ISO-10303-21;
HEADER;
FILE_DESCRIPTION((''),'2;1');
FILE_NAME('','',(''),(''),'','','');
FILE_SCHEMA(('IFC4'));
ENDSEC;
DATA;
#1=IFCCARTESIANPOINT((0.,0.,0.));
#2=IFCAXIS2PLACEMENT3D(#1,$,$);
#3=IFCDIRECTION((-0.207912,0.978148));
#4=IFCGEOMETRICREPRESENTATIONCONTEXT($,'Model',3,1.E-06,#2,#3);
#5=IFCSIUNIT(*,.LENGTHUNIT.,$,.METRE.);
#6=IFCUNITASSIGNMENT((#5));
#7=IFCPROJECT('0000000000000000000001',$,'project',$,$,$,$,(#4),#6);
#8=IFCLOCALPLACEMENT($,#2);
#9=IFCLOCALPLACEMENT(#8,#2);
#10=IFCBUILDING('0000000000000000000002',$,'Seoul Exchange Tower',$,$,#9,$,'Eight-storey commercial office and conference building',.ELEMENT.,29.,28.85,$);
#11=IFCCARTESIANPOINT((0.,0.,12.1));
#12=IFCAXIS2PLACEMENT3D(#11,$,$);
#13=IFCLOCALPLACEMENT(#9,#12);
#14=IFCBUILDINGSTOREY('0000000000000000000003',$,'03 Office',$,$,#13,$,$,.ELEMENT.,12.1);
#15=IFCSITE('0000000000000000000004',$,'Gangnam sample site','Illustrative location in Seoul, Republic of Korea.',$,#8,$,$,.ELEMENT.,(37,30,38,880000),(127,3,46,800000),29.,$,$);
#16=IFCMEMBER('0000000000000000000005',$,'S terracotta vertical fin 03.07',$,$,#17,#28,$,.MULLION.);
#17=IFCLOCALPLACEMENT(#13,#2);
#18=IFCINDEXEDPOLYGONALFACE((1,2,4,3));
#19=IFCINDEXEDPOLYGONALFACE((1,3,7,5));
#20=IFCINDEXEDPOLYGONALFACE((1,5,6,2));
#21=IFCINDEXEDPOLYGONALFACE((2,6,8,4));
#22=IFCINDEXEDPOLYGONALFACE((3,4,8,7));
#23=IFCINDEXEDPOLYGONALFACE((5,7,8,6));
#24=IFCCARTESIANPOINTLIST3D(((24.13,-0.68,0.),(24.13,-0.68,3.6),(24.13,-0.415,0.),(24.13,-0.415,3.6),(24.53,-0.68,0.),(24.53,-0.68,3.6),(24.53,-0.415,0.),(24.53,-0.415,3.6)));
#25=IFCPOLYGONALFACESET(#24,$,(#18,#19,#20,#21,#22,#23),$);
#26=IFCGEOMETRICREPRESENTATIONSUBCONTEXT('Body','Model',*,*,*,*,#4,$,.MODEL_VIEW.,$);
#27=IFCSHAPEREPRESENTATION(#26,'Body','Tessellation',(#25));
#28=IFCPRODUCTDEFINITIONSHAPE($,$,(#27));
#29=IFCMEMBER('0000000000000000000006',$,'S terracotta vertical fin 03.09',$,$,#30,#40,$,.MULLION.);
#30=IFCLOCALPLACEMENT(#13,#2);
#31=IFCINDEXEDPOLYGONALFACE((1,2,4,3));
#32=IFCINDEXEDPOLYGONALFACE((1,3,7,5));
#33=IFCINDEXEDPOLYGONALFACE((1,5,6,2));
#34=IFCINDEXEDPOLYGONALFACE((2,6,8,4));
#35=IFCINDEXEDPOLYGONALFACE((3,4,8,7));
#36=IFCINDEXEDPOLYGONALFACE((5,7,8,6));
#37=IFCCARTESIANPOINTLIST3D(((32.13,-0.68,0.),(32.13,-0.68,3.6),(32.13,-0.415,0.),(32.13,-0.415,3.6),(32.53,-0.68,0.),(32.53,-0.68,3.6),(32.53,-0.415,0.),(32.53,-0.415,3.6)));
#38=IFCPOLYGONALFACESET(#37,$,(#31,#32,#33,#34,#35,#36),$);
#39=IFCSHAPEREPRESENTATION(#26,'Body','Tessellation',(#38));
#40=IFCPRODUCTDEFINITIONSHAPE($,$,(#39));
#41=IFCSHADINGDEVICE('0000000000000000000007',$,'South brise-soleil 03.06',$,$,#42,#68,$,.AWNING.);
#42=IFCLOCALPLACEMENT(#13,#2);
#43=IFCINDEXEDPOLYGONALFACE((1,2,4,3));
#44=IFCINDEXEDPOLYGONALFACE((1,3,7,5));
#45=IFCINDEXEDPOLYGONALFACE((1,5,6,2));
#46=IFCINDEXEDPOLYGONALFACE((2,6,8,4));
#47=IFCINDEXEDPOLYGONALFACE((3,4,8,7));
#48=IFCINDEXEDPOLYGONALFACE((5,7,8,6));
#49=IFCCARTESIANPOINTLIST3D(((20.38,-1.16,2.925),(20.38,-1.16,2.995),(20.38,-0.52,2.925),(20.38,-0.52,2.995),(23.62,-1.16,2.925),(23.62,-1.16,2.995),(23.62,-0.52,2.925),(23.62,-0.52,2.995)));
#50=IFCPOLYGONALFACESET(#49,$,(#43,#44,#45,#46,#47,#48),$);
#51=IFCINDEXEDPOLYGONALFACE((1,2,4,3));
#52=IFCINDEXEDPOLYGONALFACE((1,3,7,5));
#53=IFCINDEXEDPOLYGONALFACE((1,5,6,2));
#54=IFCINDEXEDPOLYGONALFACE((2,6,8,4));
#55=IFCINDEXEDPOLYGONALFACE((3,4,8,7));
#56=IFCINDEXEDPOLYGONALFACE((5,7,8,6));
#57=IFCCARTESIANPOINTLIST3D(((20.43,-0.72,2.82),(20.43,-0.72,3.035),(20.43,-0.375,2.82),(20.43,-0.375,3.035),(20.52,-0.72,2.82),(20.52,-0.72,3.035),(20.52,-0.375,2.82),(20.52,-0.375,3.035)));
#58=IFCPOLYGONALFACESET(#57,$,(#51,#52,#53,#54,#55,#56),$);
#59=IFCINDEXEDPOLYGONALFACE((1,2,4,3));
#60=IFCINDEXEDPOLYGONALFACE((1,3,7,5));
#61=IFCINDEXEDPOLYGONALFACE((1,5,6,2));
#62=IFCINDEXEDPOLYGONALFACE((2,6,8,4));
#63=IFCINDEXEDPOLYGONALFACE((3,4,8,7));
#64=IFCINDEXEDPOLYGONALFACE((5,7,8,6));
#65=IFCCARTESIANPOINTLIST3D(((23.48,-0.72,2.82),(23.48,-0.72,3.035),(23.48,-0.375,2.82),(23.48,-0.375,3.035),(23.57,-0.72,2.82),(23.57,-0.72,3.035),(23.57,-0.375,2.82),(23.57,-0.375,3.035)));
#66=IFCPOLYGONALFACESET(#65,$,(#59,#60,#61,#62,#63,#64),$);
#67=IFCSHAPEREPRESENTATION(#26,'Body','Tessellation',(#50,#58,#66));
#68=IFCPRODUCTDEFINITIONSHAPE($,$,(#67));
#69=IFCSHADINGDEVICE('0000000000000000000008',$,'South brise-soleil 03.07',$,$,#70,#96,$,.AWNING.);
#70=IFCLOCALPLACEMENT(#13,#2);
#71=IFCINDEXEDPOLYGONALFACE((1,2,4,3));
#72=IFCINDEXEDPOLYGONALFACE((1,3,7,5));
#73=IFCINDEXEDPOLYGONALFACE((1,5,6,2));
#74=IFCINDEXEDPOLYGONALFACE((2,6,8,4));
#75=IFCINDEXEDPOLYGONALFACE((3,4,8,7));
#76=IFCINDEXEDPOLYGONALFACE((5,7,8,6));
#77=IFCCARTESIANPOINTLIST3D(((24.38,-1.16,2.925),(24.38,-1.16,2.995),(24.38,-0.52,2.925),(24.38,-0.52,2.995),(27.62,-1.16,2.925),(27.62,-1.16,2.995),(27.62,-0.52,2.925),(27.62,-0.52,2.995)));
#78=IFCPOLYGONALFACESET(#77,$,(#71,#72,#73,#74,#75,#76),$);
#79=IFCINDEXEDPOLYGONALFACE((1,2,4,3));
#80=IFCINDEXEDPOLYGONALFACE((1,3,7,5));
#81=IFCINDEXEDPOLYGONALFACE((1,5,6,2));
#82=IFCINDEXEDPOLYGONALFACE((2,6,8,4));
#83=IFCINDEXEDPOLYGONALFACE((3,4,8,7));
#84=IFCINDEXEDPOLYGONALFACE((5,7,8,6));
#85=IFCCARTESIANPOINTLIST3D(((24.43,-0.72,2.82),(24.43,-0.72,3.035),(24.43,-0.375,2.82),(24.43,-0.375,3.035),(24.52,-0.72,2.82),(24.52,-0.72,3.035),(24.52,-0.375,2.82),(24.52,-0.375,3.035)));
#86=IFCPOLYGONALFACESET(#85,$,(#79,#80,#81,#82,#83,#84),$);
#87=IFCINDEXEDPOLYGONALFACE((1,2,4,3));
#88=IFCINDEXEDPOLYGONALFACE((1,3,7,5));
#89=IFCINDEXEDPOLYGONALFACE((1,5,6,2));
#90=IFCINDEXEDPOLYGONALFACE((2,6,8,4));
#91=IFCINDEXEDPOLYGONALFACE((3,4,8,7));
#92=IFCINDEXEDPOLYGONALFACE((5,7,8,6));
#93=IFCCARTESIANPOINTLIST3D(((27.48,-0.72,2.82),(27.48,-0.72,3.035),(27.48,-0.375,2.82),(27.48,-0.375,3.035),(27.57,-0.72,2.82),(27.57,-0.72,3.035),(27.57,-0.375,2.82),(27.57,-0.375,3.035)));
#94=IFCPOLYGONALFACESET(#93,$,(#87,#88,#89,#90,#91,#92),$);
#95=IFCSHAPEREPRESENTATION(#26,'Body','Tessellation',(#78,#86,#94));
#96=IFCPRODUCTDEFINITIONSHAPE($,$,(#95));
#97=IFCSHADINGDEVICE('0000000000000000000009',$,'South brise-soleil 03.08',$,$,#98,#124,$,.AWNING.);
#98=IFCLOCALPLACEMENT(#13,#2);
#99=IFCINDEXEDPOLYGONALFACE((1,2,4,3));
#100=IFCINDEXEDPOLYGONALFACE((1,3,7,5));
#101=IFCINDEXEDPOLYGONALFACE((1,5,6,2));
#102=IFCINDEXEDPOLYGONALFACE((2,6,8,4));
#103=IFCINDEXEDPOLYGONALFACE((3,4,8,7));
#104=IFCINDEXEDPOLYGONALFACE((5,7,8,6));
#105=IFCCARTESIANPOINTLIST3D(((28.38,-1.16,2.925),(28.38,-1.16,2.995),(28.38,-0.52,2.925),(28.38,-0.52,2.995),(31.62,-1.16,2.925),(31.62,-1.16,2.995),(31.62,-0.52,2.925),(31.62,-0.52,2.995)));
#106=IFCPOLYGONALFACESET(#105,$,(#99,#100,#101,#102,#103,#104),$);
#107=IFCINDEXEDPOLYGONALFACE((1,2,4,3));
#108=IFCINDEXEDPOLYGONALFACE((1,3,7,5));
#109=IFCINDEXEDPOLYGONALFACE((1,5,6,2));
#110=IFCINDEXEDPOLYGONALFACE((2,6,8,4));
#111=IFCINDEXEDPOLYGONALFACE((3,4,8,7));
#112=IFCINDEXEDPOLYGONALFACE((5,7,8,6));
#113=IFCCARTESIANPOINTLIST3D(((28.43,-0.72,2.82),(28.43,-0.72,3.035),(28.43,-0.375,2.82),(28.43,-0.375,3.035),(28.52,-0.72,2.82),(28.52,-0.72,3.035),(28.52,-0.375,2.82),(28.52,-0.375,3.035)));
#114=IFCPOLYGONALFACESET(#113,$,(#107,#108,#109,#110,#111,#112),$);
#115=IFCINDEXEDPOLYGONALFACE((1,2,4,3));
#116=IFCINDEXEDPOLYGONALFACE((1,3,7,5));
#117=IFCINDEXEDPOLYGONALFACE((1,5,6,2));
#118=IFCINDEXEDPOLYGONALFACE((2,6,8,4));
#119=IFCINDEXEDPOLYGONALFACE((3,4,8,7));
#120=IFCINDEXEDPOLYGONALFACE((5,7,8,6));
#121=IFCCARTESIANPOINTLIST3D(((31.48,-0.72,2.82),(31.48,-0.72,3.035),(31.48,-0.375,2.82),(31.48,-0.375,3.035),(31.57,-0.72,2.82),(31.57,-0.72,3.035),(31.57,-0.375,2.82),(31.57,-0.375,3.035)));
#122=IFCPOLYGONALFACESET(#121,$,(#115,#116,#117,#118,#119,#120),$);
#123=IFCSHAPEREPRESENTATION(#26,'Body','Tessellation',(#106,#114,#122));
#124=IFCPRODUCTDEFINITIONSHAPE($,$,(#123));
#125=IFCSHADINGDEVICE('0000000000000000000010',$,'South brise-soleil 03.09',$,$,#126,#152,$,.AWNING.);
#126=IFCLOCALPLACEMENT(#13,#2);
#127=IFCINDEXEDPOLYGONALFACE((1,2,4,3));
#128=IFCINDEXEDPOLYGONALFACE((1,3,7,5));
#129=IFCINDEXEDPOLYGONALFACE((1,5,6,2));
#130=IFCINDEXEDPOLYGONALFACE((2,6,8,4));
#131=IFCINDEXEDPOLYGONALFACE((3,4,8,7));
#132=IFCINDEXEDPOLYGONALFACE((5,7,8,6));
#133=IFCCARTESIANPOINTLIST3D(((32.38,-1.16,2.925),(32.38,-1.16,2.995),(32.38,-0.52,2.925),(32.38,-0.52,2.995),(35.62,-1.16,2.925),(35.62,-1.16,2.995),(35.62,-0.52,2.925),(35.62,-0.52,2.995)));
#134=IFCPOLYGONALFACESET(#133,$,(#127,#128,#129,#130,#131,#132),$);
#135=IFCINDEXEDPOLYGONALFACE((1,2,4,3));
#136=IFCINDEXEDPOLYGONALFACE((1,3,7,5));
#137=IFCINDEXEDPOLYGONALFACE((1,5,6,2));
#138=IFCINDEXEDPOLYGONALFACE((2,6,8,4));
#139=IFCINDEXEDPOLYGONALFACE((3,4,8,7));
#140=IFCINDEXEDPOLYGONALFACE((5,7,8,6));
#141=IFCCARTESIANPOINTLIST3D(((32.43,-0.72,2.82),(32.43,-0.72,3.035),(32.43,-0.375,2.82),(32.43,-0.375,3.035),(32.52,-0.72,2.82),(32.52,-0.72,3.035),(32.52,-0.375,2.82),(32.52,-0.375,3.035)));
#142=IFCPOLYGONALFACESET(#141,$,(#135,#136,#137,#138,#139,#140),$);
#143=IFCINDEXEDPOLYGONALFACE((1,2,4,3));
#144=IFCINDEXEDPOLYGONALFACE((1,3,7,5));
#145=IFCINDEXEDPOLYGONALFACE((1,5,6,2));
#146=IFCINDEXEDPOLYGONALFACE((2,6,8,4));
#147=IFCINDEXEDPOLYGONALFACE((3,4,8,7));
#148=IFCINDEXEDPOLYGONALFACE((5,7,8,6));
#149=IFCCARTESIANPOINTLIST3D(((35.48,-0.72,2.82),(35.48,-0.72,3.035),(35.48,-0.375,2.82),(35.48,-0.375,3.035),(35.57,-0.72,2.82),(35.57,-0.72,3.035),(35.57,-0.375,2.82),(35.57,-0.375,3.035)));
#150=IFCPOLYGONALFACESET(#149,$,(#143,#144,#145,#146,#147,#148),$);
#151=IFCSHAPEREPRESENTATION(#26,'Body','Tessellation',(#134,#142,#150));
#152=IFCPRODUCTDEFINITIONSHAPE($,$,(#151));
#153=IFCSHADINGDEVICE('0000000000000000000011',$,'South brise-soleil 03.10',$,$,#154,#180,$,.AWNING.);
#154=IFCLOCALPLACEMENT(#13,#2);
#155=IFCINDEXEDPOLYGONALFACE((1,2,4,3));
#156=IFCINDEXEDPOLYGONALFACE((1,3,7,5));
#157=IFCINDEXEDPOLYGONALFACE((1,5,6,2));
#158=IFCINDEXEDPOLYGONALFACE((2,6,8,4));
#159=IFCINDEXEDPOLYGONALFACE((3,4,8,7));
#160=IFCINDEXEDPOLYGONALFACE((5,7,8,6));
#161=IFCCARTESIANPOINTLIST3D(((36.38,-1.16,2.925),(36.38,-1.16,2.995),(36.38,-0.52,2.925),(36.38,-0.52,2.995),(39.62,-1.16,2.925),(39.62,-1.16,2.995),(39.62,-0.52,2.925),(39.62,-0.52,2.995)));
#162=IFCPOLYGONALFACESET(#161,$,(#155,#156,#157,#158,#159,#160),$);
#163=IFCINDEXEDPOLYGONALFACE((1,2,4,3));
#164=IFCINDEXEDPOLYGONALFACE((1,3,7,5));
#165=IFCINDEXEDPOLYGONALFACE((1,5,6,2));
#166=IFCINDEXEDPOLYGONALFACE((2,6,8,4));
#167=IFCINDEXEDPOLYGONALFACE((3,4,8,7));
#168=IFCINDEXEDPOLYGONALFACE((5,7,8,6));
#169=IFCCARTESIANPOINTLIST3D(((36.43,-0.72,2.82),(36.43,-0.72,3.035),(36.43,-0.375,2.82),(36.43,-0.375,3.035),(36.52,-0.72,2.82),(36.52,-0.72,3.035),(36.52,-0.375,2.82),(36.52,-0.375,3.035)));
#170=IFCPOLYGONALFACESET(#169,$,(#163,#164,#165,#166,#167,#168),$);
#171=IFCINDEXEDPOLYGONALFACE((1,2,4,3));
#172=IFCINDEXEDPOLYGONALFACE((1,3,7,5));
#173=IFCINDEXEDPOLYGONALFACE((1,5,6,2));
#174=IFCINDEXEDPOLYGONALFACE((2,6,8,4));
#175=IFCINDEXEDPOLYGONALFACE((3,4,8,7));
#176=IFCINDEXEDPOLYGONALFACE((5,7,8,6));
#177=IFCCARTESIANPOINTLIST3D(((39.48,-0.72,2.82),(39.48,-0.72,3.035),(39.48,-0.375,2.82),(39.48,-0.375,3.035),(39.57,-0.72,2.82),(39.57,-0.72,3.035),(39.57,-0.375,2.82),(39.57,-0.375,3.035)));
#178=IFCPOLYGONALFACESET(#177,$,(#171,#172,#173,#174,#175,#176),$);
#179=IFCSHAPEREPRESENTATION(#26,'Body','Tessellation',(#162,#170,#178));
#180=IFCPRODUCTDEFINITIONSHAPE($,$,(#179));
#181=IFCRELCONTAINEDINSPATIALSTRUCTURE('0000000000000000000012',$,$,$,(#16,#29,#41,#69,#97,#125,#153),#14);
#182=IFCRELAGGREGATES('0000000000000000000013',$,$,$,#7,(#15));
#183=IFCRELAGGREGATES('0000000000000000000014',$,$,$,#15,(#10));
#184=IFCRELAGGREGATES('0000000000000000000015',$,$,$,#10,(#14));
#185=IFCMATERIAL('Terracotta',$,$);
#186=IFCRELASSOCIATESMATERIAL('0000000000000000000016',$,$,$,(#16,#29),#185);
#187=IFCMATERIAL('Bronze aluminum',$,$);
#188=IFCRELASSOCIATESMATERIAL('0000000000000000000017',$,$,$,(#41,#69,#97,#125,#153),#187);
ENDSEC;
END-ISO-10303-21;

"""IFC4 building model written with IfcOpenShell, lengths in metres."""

from ifc_helpers import new_model, si_unit, direction, frame, frame_2d, origin, place, context, subcontext, project, spatial, rectangle, extrude, material, element, save


model = new_model("IFC4")

# Units and contexts
model_context = context("Model", 3, precision=1e-06, world=origin(), true_north=direction((-0.207912, 0.978148)))
body_context = subcontext(model_context, "Body", "Model", "MODEL_VIEW")
ifc_project = project(units=[si_unit("LENGTHUNIT", "METRE")], contexts=[model_context])

# Site, building, storey
site_placement = place(None, origin())
site = spatial("IfcSite", under=ifc_project, at=site_placement, Name="Gangnam sample site", Description="Illustrative location in Seoul, Republic of Korea.", CompositionType="ELEMENT", RefLatitude=(37, 30, 38, 880000), RefLongitude=(127, 3, 46, 800000), RefElevation=29.0)
building_placement = place(site_placement, origin())
building = spatial("IfcBuilding", under=site, at=building_placement, Name="Seoul Exchange Tower", LongName="Eight-storey commercial office and conference building", CompositionType="ELEMENT", ElevationOfRefHeight=29.0, ElevationOfTerrain=28.85)
storey_placement = place(building_placement, frame((0.0, 0.0, 12.1)))
storey = spatial("IfcBuildingStorey", under=building, at=storey_placement, Name="03 Office", CompositionType="ELEMENT", Elevation=12.1)

# Members
ifc_material_1 = material(Name="Terracotta")
placement_1 = place(storey_placement, frame((-0.4, -0.4, 0.0), z_axis=(0.0, 0.0, 1.0), x_axis=(1.0, 0.0, 0.0)))
placement_2 = place(placement_1, origin())
element("IfcMember", 1, at=placement_2, inside=storey, material=ifc_material_1, Name="S terracotta vertical fin 03.07", PredefinedType="MULLION", context=body_context, shape_type="SweptSolid", body=[
    extrude(rectangle(XDim=0.4, YDim=0.265, at=frame_2d((0.2, 0.1325))), frame((24.53, -0.28, 0.0)), (0.0, 0.0, 1.0), 3.6),
])
element("IfcMember", 2, at=placement_2, inside=storey, material=ifc_material_1, Name="S terracotta vertical fin 03.09", PredefinedType="MULLION", context=body_context, shape_type="SweptSolid", body=[
    extrude(rectangle(XDim=0.4, YDim=0.265, at=frame_2d((0.2, 0.1325))), frame((32.53, -0.28, 0.0)), (0.0, 0.0, 1.0), 3.6),
])

# Shading devices
ifc_material_2 = material(Name="Bronze aluminum")
element("IfcShadingDevice", 3, at=placement_2, inside=storey, material=ifc_material_2, Name="South brise-soleil 03.06", PredefinedType="AWNING", context=body_context, shape_type="SweptSolid", body=[
    extrude(rectangle(XDim=3.24, YDim=0.64, at=frame_2d((1.62, 0.32))), frame((20.78, -0.76, 2.925)), (0.0, 0.0, 1.0), 0.07),
    extrude(rectangle(XDim=0.09, YDim=0.345, at=frame_2d((0.045, 0.1725))), frame((20.83, -0.32, 2.82)), (0.0, 0.0, 1.0), 0.215),
    extrude(rectangle(XDim=0.09, YDim=0.345, at=frame_2d((0.045, 0.1725))), frame((23.88, -0.32, 2.82)), (0.0, 0.0, 1.0), 0.215),
])
element("IfcShadingDevice", 4, at=placement_2, inside=storey, material=ifc_material_2, Name="South brise-soleil 03.07", PredefinedType="AWNING", context=body_context, shape_type="SweptSolid", body=[
    extrude(rectangle(XDim=3.24, YDim=0.64, at=frame_2d((1.62, 0.32))), frame((24.78, -0.76, 2.925)), (0.0, 0.0, 1.0), 0.07),
    extrude(rectangle(XDim=0.09, YDim=0.345, at=frame_2d((0.045, 0.1725))), frame((24.83, -0.32, 2.82)), (0.0, 0.0, 1.0), 0.215),
    extrude(rectangle(XDim=0.09, YDim=0.345, at=frame_2d((0.045, 0.1725))), frame((27.88, -0.32, 2.82)), (0.0, 0.0, 1.0), 0.215),
])
element("IfcShadingDevice", 5, at=placement_2, inside=storey, material=ifc_material_2, Name="South brise-soleil 03.08", PredefinedType="AWNING", context=body_context, shape_type="SweptSolid", body=[
    extrude(rectangle(XDim=3.24, YDim=0.64, at=frame_2d((1.62, 0.32))), frame((28.78, -0.76, 2.925)), (0.0, 0.0, 1.0), 0.07),
    extrude(rectangle(XDim=0.09, YDim=0.345, at=frame_2d((0.045, 0.1725))), frame((28.83, -0.32, 2.82)), (0.0, 0.0, 1.0), 0.215),
    extrude(rectangle(XDim=0.09, YDim=0.345, at=frame_2d((0.045, 0.1725))), frame((31.88, -0.32, 2.82)), (0.0, 0.0, 1.0), 0.215),
])
element("IfcShadingDevice", 6, at=placement_2, inside=storey, material=ifc_material_2, Name="South brise-soleil 03.09", PredefinedType="AWNING", context=body_context, shape_type="SweptSolid", body=[
    extrude(rectangle(XDim=3.24, YDim=0.64, at=frame_2d((1.62, 0.32))), frame((32.78, -0.76, 2.925)), (0.0, 0.0, 1.0), 0.07),
    extrude(rectangle(XDim=0.09, YDim=0.345, at=frame_2d((0.045, 0.1725))), frame((32.83, -0.32, 2.82)), (0.0, 0.0, 1.0), 0.215),
    extrude(rectangle(XDim=0.09, YDim=0.345, at=frame_2d((0.045, 0.1725))), frame((35.88, -0.32, 2.82)), (0.0, 0.0, 1.0), 0.215),
])
element("IfcShadingDevice", 7, at=placement_2, inside=storey, material=ifc_material_2, Name="South brise-soleil 03.10", PredefinedType="AWNING", context=body_context, shape_type="SweptSolid", body=[
    extrude(rectangle(XDim=3.24, YDim=0.64, at=frame_2d((1.62, 0.32))), frame((36.78, -0.76, 2.925)), (0.0, 0.0, 1.0), 0.07),
    extrude(rectangle(XDim=0.09, YDim=0.345, at=frame_2d((0.045, 0.1725))), frame((36.83, -0.32, 2.82)), (0.0, 0.0, 1.0), 0.215),
    extrude(rectangle(XDim=0.09, YDim=0.345, at=frame_2d((0.045, 0.1725))), frame((39.88, -0.32, 2.82)), (0.0, 0.0, 1.0), 0.215),
])

save(model, "model.ifc")
